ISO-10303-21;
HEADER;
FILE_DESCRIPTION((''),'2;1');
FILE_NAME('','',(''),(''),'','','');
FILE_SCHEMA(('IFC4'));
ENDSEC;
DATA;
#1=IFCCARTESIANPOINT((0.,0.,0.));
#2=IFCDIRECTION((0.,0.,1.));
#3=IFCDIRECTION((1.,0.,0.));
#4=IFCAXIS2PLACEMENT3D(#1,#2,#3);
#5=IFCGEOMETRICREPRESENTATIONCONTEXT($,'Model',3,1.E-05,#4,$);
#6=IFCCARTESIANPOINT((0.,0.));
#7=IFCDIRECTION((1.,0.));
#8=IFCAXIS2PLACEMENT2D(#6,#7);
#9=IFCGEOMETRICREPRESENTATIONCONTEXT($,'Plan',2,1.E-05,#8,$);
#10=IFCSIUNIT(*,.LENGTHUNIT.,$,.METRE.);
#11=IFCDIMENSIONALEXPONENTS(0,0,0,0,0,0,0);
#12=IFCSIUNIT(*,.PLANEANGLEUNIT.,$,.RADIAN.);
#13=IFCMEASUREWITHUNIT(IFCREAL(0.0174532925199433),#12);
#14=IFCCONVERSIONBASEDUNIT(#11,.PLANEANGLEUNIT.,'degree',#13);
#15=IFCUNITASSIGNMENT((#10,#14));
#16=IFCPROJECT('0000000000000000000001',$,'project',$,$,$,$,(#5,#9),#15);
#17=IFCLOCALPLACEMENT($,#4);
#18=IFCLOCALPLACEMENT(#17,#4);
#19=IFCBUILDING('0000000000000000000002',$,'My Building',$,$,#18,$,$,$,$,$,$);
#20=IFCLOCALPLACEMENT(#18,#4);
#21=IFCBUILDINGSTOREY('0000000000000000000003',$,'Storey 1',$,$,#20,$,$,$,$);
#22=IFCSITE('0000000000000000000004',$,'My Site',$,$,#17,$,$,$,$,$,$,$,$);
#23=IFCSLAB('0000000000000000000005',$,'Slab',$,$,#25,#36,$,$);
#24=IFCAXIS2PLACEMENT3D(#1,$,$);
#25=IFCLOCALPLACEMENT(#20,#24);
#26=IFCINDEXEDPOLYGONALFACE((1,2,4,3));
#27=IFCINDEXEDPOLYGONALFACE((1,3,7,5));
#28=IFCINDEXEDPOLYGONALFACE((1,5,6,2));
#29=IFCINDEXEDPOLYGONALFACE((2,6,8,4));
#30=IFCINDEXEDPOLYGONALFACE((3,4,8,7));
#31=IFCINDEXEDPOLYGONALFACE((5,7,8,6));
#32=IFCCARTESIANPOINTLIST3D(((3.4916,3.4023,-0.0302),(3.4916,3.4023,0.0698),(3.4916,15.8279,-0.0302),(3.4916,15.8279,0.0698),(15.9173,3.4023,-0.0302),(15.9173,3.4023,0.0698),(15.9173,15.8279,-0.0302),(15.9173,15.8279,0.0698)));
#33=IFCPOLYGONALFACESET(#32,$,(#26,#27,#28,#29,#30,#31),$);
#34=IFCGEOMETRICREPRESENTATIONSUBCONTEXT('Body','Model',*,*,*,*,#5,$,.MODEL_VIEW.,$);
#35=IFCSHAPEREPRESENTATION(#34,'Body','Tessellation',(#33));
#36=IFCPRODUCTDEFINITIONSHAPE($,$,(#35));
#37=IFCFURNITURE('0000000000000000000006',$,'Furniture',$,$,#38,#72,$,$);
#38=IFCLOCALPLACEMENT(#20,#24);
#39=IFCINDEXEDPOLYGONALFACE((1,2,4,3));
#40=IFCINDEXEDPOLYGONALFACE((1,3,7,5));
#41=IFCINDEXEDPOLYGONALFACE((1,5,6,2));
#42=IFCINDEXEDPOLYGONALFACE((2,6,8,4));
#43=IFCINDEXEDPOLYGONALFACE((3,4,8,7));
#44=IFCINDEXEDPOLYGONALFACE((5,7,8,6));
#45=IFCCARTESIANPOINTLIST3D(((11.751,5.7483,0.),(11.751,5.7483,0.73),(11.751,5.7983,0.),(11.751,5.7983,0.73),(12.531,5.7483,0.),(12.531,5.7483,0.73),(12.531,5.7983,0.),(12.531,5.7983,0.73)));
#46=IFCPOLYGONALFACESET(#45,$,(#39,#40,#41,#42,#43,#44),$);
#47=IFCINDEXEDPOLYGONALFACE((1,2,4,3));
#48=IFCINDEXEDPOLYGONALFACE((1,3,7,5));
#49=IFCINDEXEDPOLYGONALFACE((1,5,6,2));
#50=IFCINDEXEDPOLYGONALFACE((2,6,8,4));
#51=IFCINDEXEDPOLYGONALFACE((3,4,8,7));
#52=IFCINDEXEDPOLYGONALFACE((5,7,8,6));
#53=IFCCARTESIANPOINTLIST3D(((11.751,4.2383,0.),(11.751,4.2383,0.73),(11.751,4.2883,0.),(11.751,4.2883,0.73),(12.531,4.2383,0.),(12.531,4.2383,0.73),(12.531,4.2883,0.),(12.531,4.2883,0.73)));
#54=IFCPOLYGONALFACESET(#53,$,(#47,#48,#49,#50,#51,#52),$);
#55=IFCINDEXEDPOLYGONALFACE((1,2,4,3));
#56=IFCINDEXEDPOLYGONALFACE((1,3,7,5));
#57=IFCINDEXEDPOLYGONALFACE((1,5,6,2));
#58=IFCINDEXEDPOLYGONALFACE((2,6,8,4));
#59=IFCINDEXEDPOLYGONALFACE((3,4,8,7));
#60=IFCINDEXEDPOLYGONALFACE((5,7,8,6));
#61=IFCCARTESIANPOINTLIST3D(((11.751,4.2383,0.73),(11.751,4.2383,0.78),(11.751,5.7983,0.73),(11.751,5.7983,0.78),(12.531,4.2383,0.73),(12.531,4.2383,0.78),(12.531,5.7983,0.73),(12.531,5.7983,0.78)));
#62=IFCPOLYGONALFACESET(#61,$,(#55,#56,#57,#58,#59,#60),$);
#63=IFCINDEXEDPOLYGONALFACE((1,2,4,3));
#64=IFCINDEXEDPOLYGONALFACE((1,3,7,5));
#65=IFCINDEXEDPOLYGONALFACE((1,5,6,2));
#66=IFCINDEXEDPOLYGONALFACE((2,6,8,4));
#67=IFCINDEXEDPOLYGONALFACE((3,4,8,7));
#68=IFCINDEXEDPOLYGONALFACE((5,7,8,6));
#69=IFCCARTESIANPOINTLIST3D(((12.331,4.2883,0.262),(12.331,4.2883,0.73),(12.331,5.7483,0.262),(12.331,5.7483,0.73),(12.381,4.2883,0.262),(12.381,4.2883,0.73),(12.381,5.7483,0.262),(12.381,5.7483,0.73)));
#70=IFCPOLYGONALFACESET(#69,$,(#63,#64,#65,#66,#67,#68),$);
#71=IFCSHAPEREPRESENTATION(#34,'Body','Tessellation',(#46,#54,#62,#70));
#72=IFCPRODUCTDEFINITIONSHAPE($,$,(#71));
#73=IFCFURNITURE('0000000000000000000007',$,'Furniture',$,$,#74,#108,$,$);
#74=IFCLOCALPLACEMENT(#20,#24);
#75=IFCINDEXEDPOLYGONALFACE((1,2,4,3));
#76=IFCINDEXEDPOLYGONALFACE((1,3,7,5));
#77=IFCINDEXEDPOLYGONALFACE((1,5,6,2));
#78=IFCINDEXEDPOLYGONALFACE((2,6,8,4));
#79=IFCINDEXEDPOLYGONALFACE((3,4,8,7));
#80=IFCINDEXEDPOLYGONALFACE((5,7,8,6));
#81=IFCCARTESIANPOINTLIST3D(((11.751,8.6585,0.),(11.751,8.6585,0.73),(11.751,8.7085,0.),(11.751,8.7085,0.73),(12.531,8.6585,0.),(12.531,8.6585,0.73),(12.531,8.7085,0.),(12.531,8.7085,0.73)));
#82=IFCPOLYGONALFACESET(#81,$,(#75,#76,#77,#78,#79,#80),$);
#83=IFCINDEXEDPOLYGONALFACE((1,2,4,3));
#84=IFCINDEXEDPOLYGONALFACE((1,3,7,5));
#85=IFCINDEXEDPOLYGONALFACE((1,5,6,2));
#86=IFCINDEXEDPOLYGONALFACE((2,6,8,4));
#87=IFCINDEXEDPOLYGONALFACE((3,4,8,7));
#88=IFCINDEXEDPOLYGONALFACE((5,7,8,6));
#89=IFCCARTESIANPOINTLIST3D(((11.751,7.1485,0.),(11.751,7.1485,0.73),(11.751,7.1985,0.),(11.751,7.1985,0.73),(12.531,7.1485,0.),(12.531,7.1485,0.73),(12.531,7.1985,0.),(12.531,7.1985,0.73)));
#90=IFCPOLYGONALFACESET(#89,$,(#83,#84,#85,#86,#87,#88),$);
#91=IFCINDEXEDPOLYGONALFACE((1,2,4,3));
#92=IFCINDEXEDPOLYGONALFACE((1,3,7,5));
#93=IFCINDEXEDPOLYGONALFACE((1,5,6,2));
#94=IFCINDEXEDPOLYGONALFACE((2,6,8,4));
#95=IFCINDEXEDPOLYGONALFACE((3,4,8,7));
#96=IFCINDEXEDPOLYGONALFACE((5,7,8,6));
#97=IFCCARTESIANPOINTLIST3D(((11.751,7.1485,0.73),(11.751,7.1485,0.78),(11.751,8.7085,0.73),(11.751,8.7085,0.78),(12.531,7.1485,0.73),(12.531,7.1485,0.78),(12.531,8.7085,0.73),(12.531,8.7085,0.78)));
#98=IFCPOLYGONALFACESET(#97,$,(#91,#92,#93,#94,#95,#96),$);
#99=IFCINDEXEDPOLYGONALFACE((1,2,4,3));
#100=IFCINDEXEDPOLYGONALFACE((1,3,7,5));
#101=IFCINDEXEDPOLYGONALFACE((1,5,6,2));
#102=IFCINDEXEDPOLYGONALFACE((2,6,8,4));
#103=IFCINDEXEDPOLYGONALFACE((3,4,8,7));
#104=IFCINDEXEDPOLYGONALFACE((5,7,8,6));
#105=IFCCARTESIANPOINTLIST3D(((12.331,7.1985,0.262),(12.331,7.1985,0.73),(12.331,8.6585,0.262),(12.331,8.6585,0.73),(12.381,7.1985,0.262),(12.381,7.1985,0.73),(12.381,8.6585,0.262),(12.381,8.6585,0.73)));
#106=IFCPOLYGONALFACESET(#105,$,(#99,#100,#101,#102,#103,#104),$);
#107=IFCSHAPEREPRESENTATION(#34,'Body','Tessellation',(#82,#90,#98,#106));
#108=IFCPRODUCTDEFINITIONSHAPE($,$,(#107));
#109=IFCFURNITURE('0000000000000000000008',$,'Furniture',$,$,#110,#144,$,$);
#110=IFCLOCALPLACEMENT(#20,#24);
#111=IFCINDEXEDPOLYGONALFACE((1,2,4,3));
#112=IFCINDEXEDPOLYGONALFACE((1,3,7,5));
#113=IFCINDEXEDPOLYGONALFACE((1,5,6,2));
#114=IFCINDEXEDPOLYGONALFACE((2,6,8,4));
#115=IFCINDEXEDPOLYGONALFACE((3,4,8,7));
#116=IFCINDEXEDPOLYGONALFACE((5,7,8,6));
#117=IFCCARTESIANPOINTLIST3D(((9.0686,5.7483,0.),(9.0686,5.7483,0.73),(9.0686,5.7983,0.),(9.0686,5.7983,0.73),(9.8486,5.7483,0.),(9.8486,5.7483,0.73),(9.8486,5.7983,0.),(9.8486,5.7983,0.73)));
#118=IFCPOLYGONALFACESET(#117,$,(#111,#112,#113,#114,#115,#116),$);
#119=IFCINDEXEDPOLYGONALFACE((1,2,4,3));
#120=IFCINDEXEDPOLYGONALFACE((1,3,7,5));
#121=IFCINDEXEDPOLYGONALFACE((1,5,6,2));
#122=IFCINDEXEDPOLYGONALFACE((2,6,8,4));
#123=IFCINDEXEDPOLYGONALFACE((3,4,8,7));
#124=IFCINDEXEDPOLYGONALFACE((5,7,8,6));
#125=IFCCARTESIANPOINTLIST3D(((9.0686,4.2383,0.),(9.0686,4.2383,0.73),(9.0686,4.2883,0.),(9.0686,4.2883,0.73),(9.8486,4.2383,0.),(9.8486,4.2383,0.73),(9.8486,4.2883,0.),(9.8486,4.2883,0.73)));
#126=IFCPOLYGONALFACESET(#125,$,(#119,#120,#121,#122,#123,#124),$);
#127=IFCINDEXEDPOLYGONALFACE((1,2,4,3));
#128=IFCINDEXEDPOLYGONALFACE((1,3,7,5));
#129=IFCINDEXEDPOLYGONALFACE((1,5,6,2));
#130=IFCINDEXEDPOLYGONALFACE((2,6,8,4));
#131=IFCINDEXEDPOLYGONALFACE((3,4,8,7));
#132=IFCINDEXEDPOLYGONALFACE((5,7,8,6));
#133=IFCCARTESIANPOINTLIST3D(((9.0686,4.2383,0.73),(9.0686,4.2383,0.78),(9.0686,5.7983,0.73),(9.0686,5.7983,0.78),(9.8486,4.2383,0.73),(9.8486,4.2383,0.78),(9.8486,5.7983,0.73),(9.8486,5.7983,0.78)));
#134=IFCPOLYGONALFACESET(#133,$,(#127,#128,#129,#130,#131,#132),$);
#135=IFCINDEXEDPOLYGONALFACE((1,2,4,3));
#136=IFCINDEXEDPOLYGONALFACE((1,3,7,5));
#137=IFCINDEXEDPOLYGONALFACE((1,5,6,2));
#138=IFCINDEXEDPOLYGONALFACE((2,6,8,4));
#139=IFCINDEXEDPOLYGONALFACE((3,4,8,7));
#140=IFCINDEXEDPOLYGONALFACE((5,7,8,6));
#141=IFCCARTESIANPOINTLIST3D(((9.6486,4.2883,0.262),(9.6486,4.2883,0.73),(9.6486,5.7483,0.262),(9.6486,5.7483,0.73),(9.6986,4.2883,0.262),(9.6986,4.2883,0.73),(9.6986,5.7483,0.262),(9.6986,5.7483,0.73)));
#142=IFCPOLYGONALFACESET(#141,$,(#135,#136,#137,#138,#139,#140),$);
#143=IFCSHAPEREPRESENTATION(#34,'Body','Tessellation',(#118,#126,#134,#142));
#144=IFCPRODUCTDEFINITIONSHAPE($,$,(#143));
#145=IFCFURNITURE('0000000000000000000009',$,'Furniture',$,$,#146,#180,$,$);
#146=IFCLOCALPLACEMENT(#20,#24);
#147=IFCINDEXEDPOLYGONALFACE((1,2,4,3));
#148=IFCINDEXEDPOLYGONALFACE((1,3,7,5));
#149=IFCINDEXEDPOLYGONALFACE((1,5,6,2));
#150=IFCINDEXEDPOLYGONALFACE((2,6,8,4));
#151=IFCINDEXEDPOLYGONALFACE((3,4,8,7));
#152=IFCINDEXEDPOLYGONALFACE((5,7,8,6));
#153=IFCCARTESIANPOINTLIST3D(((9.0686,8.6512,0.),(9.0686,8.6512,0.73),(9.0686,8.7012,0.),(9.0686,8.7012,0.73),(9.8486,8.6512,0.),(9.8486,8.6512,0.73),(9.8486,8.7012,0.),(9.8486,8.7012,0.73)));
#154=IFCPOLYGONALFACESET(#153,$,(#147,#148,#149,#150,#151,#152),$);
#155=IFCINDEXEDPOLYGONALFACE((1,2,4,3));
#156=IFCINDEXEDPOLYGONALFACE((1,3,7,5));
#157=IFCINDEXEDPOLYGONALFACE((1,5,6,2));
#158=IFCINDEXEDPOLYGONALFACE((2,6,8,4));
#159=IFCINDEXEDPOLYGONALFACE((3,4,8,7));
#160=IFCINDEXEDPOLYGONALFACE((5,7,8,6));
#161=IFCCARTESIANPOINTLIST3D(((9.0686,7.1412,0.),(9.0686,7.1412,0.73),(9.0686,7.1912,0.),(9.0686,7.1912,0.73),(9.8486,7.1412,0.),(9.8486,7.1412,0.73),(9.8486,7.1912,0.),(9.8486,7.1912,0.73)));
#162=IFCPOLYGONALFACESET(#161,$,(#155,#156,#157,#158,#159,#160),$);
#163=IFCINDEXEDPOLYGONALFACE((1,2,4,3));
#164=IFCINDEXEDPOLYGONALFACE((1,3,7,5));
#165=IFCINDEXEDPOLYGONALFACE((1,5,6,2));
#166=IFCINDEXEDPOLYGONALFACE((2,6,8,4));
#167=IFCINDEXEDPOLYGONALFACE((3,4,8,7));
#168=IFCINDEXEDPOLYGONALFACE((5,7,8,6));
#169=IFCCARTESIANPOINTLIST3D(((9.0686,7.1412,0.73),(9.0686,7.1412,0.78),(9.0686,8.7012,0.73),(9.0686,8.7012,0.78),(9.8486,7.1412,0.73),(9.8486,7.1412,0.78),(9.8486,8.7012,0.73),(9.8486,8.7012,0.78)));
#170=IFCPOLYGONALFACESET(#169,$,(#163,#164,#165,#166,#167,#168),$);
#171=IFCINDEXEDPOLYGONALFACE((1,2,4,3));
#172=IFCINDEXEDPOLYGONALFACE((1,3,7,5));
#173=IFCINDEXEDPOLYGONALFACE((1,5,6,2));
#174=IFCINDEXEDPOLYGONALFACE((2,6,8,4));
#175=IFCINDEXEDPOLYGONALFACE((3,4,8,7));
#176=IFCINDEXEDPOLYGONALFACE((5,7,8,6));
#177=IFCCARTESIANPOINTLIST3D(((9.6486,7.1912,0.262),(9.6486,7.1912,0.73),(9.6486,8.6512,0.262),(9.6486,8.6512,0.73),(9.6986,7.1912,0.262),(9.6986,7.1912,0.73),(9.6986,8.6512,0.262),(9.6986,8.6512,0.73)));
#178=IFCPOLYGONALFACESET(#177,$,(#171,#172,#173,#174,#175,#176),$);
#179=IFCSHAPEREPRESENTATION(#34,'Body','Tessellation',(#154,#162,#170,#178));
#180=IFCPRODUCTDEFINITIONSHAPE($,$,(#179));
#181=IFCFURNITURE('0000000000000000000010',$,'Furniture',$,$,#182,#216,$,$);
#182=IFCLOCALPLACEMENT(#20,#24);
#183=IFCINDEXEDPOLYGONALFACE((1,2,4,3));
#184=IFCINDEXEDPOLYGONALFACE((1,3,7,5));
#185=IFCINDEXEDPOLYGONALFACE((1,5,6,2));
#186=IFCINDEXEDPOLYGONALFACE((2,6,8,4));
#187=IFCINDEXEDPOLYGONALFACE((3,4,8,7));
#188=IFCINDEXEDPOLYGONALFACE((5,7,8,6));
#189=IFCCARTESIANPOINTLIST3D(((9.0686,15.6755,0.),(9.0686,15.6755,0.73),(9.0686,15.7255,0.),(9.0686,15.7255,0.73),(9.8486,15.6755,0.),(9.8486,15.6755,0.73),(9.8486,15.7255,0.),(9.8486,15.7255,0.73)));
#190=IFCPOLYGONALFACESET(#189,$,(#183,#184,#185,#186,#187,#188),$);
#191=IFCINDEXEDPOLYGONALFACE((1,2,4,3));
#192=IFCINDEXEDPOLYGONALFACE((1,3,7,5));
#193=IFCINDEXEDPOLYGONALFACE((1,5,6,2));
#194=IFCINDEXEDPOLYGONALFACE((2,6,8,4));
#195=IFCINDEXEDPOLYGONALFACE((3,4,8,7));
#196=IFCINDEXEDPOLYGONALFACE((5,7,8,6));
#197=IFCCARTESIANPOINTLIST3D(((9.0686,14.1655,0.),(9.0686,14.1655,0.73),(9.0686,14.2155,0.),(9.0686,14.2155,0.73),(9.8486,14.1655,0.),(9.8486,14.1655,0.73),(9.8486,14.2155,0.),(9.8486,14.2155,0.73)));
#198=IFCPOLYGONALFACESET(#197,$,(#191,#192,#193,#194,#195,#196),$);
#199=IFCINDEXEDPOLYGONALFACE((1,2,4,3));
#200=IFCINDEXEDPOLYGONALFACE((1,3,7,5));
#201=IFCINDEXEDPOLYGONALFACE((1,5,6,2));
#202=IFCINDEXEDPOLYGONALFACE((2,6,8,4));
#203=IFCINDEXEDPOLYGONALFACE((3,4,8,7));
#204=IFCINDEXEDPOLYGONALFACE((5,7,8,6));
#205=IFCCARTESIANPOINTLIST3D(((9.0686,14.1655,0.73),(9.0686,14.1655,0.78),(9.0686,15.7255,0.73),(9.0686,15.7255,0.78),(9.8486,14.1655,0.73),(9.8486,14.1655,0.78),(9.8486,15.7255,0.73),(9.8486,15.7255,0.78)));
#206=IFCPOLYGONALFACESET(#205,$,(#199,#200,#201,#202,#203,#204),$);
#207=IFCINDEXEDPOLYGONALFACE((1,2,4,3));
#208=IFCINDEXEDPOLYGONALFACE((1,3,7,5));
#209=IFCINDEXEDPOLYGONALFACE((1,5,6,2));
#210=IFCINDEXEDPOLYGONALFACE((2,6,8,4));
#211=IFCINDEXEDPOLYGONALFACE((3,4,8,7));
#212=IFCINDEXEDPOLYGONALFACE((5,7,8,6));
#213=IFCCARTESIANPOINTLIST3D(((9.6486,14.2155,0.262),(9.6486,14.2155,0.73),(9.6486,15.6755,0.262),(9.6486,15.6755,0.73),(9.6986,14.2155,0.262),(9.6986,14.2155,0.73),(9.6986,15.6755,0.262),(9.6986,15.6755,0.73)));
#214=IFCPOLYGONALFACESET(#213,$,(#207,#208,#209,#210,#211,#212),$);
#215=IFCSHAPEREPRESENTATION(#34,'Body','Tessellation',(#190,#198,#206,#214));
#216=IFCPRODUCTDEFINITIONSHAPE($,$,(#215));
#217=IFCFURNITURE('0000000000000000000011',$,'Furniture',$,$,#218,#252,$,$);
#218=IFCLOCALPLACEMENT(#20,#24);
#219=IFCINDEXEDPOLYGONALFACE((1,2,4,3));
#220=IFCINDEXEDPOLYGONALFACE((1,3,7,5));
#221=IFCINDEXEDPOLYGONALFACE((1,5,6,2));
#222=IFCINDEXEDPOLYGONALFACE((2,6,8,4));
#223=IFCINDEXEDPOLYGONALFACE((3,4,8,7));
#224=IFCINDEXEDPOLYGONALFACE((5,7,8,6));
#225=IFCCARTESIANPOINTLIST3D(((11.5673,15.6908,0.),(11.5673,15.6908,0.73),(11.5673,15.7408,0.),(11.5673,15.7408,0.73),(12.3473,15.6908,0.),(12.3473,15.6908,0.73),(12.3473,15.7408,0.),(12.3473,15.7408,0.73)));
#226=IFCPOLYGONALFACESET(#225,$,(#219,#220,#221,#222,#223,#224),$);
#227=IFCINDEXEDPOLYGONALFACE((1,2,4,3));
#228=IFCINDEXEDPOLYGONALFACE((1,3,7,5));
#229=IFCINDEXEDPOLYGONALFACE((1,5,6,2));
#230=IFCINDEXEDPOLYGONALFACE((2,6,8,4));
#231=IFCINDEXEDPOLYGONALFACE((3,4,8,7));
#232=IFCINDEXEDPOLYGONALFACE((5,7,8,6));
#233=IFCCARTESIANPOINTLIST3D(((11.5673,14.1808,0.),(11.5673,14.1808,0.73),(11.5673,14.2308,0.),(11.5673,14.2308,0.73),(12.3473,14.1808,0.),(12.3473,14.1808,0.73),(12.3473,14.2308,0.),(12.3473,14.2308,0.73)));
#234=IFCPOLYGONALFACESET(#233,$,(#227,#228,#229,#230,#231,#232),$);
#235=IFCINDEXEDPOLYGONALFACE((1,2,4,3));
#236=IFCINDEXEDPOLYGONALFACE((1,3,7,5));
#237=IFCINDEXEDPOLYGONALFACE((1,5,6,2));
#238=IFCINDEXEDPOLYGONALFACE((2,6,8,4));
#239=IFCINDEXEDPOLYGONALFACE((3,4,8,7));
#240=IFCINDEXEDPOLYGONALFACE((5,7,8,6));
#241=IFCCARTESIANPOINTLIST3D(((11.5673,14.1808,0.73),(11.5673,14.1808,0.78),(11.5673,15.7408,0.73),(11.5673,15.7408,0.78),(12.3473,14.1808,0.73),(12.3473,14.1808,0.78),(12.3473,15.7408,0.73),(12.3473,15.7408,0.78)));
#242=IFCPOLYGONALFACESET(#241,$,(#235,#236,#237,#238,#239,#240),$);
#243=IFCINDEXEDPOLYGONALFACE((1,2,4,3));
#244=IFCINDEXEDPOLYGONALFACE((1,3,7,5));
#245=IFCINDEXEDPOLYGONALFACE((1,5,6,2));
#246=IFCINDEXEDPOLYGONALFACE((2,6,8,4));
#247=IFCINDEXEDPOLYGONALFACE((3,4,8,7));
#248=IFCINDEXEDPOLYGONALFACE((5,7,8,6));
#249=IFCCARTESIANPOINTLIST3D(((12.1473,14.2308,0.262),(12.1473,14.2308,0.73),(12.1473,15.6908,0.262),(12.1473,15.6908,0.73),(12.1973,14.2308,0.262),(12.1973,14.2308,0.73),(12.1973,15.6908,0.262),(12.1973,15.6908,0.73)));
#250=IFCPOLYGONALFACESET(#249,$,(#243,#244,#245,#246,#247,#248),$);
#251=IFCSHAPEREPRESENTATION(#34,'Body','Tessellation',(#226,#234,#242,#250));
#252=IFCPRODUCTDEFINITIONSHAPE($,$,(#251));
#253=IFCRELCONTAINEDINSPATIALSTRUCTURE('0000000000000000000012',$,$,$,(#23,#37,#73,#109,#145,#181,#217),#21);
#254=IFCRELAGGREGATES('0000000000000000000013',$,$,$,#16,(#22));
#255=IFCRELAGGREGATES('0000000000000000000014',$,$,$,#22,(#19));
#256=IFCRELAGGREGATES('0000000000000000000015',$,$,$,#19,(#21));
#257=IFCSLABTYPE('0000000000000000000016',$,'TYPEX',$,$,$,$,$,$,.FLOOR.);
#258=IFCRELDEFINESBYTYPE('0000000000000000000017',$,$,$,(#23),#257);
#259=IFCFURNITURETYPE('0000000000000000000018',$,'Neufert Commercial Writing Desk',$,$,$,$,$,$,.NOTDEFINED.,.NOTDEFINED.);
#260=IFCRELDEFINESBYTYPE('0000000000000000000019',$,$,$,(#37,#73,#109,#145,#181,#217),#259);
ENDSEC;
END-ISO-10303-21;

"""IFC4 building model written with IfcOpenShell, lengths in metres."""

from ifc_helpers import new_model, entity, si_unit, converted_unit, frame, origin_with_axes, origin_2d_with_axis, place, context, subcontext, project, spatial, line, indexed_curve, outline, extrude, shape, source, transform, mapped, type_object, type_shapes, element, save


model = new_model("IFC4")

# Units and contexts
model_context = context("Model", 3, precision=1e-05, world=origin_with_axes())
plan_context = context("Plan", 2, precision=1e-05, world=origin_2d_with_axis())
body_context_1 = subcontext(model_context, "Body", "Model", "MODEL_VIEW")
body_context_2 = subcontext(plan_context, "Body", "Plan", "PLAN_VIEW")
ifc_project = project(units=[si_unit("LENGTHUNIT", "METRE"), converted_unit("PLANEANGLEUNIT", "degree", entity("IfcReal", 0.0174532925199433), si_unit("PLANEANGLEUNIT", "RADIAN"), dimensions=[0, 0, 0, 0, 0, 0, 0])], contexts=[model_context, plan_context])

# Site, building, storey
site_placement = place(None, origin_with_axes())
site = spatial("IfcSite", under=ifc_project, at=site_placement, Name="My Site")
building_placement = place(site_placement, origin_with_axes())
building = spatial("IfcBuilding", under=site, at=building_placement, Name="My Building")
storey_placement = place(building_placement, origin_with_axes())
storey = spatial("IfcBuildingStorey", under=building, at=storey_placement, Name="Storey 1")

# Slab
slab_type = type_object("IfcSlabType", Name="TYPEX", PredefinedType="FLOOR")
slab_placement = place(storey_placement, frame((0.0, 0.0, -0.0302), z_axis=(0.0, 0.0, 1.0), x_axis=(1.0, 0.0, 0.0)))
element("IfcSlab", 1, at=slab_placement, inside=storey, type_object=slab_type, Name="Slab", context=body_context_1, shape_type="SweptSolid", body=[
    extrude(outline(indexed_curve([(3.4916, 3.4023), (3.4916, 15.8279), (15.9173, 15.8279), (15.9173, 3.4023)], segments=[line(3, 2), line(2, 1), line(1, 4), line(4, 3)], self_intersect=False)), None, (0.0, 0.0, 1.0), 0.1),
])

# Furniture
furniture_type_1 = type_object("IfcFurnitureType", Name="Neufert Commercial Writing Desk", AssemblyPlace="NOTDEFINED", PredefinedType="NOTDEFINED")
shared_shape_1 = source(origin_with_axes(), body_context_1, "Body", "SweptSolid", [
    extrude(outline(indexed_curve([(0.0, 0.0), (0.05, 0.0), (0.05, 0.78), (0.0, 0.78)], segments=[line(1, 2, 3, 4, 1)])), origin_with_axes(), (0.0, 0.0, 1.0), 0.73),
    extrude(outline(indexed_curve([(0.0, 0.0), (0.05, 0.0), (0.05, 0.78), (0.0, 0.78)], segments=[line(1, 2, 3, 4, 1)])), frame((1.51, 0.0, 0.0), z_axis=(0.0, 0.0, 1.0), x_axis=(1.0, 0.0, 0.0)), (0.0, 0.0, 1.0), 0.73),
    extrude(outline(indexed_curve([(0.0, 0.0), (1.56, 0.0), (1.56, 0.78), (0.0, 0.78)], segments=[line(1, 2, 3, 4, 1)])), frame((0.0, 0.0, 0.73), z_axis=(0.0, 0.0, 1.0), x_axis=(1.0, 0.0, 0.0)), (0.0, 0.0, 1.0), 0.05),
    extrude(outline(indexed_curve([(0.05, 0.58), (1.51, 0.58), (1.51, 0.63), (0.05, 0.63)], segments=[line(1, 2, 3, 4, 1)])), frame((0.0, 0.0, 0.262), z_axis=(0.0, 0.0, 1.0), x_axis=(1.0, 0.0, 0.0)), (0.0, 0.0, 1.0), 0.468),
])
shared_shape_2 = source(origin_with_axes(), body_context_2, "Body", "Curve2D", [
    entity("IfcIndexedPolyCurve", entity("IfcCartesianPointList2D", [[0.0, 0.0], [1.56, 0.0], [1.56, 0.78], [0.0, 0.78]]), [entity("IfcLineIndex", [1, 2, 3, 4, 1])]),
])
type_shapes(furniture_type_1, [shared_shape_1, shared_shape_2])
for number, where, z_axis, x_axis, name in (
    (2, (11.751, 5.7983, 0.0), (0.0, 0.0, 1.0), (0.0, -1.0, 0.0), "Furniture"),
    (3, (11.751, 8.7085, 0.0), (0.0, 0.0, 1.0), (0.0, -1.0, 0.0), "Furniture"),
    (4, (9.0686, 5.7983, 0.0), (0.0, 0.0, 1.0), (0.0, -1.0, 0.0), "Furniture"),
    (5, (9.0686, 8.7012, 0.0), (0.0, 0.0, 1.0), (0.0, -1.0, 0.0), "Furniture"),
    (6, (9.0686, 15.7255, 0.0), (0.0, 0.0, 1.0), (0.0, -1.0, 0.0), "Furniture"),
    (7, (11.5673, 15.7408, 0.0), (0.0, 0.0, 1.0), (0.0, -1.0, 0.0), "Furniture"),
):
    element("IfcFurniture", number, at=place(storey_placement, frame(where, z_axis=z_axis, x_axis=x_axis)), inside=storey, type_object=furniture_type_1, Name=name, shapes=[
        shape(body_context_1, "Body", "MappedRepresentation", [mapped(shared_shape_1, transform((0.0, 0.0, 0.0), x_axis=(1.0, 0.0, 0.0), y_axis=(0.0, 1.0, 0.0), z_axis=(0.0, 0.0, 1.0), scale=1.0))]),
        shape(body_context_2, "Body", "MappedRepresentation", [mapped(shared_shape_2, transform((0.0, 0.0, 0.0), x_axis=(1.0, 0.0, 0.0), y_axis=(0.0, 1.0, 0.0), z_axis=(0.0, 0.0, 1.0), scale=1.0))]),
    ])

save(model, "model.ifc")
